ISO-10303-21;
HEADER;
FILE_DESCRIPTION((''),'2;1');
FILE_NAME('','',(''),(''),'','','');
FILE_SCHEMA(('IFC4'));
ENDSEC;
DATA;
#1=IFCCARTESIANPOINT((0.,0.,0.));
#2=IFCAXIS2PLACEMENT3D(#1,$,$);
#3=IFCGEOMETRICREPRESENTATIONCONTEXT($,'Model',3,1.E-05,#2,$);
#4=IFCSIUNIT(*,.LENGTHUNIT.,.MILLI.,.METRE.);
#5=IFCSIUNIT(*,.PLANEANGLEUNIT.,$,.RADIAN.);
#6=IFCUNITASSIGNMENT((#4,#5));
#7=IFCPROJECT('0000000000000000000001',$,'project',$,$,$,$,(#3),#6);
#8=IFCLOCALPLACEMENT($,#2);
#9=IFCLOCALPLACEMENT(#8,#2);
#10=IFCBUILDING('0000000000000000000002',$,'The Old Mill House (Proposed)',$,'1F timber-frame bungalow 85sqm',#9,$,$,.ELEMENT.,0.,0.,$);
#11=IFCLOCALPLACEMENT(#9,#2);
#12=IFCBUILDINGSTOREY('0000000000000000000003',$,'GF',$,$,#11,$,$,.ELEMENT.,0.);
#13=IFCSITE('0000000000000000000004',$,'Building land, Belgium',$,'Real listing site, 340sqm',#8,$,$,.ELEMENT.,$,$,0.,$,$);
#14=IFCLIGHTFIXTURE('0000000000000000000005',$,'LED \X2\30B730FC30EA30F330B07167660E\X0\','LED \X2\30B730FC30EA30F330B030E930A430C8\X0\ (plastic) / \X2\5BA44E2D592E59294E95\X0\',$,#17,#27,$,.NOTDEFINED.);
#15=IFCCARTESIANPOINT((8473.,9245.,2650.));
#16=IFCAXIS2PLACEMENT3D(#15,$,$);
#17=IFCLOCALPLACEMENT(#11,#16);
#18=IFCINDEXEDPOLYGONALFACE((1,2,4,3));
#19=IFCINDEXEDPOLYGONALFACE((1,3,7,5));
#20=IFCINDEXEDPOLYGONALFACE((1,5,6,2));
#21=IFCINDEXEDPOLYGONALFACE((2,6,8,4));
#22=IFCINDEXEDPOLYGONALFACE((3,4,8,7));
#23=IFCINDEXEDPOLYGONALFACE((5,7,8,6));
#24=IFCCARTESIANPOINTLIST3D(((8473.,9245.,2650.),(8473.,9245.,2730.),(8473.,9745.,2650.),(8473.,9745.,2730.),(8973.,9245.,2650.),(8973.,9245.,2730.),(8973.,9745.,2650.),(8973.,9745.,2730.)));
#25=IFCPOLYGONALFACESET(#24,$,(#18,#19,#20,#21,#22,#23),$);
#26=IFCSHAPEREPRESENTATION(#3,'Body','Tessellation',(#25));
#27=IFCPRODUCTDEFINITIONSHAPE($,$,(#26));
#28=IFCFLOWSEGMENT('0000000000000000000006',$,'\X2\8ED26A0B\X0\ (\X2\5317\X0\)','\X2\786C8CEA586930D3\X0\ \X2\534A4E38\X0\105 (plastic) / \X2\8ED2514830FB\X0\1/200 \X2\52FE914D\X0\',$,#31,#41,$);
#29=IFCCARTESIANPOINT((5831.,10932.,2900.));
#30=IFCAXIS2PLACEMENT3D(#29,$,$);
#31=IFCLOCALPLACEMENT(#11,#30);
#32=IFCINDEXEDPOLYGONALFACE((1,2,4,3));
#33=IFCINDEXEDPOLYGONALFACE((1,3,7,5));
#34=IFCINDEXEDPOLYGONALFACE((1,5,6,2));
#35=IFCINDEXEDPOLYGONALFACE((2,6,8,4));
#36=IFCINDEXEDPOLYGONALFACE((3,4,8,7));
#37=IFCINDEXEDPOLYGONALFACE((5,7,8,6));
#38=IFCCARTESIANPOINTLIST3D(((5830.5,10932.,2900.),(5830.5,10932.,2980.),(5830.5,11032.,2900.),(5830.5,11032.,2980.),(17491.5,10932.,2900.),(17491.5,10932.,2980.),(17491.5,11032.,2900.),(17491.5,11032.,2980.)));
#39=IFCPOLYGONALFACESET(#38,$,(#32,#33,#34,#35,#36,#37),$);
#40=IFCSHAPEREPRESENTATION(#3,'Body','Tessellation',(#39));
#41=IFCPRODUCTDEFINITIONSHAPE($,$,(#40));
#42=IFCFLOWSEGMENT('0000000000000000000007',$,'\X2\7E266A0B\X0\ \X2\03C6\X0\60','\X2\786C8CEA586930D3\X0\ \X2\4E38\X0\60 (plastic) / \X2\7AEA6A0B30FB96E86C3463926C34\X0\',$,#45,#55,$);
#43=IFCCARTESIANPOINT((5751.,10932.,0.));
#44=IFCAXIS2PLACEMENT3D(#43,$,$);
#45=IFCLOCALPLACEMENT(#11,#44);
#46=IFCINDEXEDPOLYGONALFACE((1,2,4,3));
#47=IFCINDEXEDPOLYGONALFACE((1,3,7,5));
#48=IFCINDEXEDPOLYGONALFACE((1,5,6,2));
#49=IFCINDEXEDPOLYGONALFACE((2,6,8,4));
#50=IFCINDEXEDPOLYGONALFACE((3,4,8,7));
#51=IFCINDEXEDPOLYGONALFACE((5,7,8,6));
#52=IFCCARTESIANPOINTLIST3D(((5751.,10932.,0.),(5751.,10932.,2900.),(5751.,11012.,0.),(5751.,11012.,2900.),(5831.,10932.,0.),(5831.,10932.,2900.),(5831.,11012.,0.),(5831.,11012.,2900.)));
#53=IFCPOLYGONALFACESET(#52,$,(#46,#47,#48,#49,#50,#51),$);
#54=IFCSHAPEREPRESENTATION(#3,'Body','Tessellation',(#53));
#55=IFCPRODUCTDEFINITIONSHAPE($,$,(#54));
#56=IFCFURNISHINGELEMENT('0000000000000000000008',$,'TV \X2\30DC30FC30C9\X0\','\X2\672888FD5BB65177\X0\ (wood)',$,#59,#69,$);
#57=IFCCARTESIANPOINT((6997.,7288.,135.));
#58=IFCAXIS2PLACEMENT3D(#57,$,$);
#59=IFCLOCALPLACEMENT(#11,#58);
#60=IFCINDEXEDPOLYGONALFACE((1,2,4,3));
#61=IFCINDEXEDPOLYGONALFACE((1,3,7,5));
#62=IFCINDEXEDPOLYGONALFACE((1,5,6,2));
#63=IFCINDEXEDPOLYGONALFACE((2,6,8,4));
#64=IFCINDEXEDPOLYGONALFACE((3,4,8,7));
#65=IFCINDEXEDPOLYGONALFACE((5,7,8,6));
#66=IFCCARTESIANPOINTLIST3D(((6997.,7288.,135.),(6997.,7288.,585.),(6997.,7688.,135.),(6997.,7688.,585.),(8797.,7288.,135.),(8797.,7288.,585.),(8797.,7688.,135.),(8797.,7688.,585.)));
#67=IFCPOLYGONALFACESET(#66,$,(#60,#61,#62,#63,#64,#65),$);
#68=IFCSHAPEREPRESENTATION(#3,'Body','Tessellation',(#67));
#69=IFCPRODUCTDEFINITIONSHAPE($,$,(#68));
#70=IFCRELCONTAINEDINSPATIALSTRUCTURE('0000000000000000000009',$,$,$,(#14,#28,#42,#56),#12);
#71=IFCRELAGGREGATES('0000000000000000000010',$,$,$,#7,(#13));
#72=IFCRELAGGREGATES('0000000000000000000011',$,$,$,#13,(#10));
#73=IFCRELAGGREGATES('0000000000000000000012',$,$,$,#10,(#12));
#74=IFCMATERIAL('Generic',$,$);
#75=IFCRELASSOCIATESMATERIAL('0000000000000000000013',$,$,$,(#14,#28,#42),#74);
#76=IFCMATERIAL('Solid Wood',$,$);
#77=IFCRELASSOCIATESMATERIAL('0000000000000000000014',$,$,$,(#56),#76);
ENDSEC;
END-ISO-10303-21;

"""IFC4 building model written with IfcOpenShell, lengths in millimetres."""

from ifc_helpers import new_model, si_unit, frame, frame_2d, origin, place, context, project, spatial, rectangle, extrude, material, element, save


model = new_model("IFC4")

# Units and contexts
model_context = context("Model", 3, precision=1e-05, world=origin())
ifc_project = project(units=[si_unit("LENGTHUNIT", "METRE", prefix="MILLI"), si_unit("PLANEANGLEUNIT", "RADIAN")], contexts=[model_context])

# Site, building, storey
site_placement = place(None, origin())
site = spatial("IfcSite", under=ifc_project, at=site_placement, Name="Building land, Belgium", ObjectType="Real listing site, 340sqm", CompositionType="ELEMENT", RefElevation=0.0)
building_placement = place(site_placement, origin())
building = spatial("IfcBuilding", under=site, at=building_placement, Name="The Old Mill House (Proposed)", ObjectType="1F timber-frame bungalow 85sqm", CompositionType="ELEMENT", ElevationOfRefHeight=0.0, ElevationOfTerrain=0.0)
storey_placement = place(building_placement, origin())
storey = spatial("IfcBuildingStorey", under=building, at=storey_placement, Name="GF", CompositionType="ELEMENT", Elevation=0.0)

# Shared definitions
ifc_material_1 = material(Name="Solid Wood")

# Shared definitions
ifc_material_2 = material(Name="Generic")

# Light fixture
light_fixture_placement = place(storey_placement, frame((8473.0, 9245.0, 2650.0)))
element("IfcLightFixture", 1, at=light_fixture_placement, inside=storey, material=ifc_material_2, Name="LED シーリング照明", Description="LED シーリングライト (plastic) / 室中央天井", PredefinedType="NOTDEFINED", context=model_context, shape_type="SweptSolid", body=[
    extrude(rectangle(XDim=500.0, YDim=500.0, at=frame_2d((250.0, 250.0))), frame((8473.0, 9245.0, 2650.0)), (0.0, 0.0, 1.0), 80.0),
])

# Flow segments
flow_segment_1_placement = place(storey_placement, frame((5831.0, 10932.0, 2900.0)))
element("IfcFlowSegment", 2, at=flow_segment_1_placement, inside=storey, material=ifc_material_2, Name="軒樋 (北)", Description="硬質塩ビ 半丸105 (plastic) / 軒先・1/200 勾配", context=model_context, shape_type="SweptSolid", body=[
    extrude(rectangle(XDim=11661.0, YDim=100.0, at=frame_2d((5830.0, 50.0))), frame((5831.0, 10932.0, 2900.0)), (0.0, 0.0, 1.0), 80.0),
])
flow_segment_2_placement = place(storey_placement, frame((5751.0, 10932.0, 0.0)))
element("IfcFlowSegment", 3, at=flow_segment_2_placement, inside=storey, material=ifc_material_2, Name="縦樋 φ60", Description="硬質塩ビ 丸60 (plastic) / 竪樋・雨水排水", context=model_context, shape_type="SweptSolid", body=[
    extrude(rectangle(XDim=80.0, YDim=80.0, at=frame_2d((40.0, 40.0))), frame((5751.0, 10932.0, 0.0)), (0.0, 0.0, 1.0), 2900.0),
])

# Furnishing element
furnishing_placement = place(storey_placement, frame((6997.0, 7288.0, 135.0)))
element("IfcFurnishingElement", 4, at=furnishing_placement, inside=storey, material=ifc_material_1, Name="TV ボード", Description="木製家具 (wood)", context=model_context, shape_type="SweptSolid", body=[
    extrude(rectangle(XDim=1800.0, YDim=400.0, at=frame_2d((900.0, 200.0))), frame((6997.0, 7288.0, 135.0)), (0.0, 0.0, 1.0), 450.0),
])

save(model, "model.ifc")
